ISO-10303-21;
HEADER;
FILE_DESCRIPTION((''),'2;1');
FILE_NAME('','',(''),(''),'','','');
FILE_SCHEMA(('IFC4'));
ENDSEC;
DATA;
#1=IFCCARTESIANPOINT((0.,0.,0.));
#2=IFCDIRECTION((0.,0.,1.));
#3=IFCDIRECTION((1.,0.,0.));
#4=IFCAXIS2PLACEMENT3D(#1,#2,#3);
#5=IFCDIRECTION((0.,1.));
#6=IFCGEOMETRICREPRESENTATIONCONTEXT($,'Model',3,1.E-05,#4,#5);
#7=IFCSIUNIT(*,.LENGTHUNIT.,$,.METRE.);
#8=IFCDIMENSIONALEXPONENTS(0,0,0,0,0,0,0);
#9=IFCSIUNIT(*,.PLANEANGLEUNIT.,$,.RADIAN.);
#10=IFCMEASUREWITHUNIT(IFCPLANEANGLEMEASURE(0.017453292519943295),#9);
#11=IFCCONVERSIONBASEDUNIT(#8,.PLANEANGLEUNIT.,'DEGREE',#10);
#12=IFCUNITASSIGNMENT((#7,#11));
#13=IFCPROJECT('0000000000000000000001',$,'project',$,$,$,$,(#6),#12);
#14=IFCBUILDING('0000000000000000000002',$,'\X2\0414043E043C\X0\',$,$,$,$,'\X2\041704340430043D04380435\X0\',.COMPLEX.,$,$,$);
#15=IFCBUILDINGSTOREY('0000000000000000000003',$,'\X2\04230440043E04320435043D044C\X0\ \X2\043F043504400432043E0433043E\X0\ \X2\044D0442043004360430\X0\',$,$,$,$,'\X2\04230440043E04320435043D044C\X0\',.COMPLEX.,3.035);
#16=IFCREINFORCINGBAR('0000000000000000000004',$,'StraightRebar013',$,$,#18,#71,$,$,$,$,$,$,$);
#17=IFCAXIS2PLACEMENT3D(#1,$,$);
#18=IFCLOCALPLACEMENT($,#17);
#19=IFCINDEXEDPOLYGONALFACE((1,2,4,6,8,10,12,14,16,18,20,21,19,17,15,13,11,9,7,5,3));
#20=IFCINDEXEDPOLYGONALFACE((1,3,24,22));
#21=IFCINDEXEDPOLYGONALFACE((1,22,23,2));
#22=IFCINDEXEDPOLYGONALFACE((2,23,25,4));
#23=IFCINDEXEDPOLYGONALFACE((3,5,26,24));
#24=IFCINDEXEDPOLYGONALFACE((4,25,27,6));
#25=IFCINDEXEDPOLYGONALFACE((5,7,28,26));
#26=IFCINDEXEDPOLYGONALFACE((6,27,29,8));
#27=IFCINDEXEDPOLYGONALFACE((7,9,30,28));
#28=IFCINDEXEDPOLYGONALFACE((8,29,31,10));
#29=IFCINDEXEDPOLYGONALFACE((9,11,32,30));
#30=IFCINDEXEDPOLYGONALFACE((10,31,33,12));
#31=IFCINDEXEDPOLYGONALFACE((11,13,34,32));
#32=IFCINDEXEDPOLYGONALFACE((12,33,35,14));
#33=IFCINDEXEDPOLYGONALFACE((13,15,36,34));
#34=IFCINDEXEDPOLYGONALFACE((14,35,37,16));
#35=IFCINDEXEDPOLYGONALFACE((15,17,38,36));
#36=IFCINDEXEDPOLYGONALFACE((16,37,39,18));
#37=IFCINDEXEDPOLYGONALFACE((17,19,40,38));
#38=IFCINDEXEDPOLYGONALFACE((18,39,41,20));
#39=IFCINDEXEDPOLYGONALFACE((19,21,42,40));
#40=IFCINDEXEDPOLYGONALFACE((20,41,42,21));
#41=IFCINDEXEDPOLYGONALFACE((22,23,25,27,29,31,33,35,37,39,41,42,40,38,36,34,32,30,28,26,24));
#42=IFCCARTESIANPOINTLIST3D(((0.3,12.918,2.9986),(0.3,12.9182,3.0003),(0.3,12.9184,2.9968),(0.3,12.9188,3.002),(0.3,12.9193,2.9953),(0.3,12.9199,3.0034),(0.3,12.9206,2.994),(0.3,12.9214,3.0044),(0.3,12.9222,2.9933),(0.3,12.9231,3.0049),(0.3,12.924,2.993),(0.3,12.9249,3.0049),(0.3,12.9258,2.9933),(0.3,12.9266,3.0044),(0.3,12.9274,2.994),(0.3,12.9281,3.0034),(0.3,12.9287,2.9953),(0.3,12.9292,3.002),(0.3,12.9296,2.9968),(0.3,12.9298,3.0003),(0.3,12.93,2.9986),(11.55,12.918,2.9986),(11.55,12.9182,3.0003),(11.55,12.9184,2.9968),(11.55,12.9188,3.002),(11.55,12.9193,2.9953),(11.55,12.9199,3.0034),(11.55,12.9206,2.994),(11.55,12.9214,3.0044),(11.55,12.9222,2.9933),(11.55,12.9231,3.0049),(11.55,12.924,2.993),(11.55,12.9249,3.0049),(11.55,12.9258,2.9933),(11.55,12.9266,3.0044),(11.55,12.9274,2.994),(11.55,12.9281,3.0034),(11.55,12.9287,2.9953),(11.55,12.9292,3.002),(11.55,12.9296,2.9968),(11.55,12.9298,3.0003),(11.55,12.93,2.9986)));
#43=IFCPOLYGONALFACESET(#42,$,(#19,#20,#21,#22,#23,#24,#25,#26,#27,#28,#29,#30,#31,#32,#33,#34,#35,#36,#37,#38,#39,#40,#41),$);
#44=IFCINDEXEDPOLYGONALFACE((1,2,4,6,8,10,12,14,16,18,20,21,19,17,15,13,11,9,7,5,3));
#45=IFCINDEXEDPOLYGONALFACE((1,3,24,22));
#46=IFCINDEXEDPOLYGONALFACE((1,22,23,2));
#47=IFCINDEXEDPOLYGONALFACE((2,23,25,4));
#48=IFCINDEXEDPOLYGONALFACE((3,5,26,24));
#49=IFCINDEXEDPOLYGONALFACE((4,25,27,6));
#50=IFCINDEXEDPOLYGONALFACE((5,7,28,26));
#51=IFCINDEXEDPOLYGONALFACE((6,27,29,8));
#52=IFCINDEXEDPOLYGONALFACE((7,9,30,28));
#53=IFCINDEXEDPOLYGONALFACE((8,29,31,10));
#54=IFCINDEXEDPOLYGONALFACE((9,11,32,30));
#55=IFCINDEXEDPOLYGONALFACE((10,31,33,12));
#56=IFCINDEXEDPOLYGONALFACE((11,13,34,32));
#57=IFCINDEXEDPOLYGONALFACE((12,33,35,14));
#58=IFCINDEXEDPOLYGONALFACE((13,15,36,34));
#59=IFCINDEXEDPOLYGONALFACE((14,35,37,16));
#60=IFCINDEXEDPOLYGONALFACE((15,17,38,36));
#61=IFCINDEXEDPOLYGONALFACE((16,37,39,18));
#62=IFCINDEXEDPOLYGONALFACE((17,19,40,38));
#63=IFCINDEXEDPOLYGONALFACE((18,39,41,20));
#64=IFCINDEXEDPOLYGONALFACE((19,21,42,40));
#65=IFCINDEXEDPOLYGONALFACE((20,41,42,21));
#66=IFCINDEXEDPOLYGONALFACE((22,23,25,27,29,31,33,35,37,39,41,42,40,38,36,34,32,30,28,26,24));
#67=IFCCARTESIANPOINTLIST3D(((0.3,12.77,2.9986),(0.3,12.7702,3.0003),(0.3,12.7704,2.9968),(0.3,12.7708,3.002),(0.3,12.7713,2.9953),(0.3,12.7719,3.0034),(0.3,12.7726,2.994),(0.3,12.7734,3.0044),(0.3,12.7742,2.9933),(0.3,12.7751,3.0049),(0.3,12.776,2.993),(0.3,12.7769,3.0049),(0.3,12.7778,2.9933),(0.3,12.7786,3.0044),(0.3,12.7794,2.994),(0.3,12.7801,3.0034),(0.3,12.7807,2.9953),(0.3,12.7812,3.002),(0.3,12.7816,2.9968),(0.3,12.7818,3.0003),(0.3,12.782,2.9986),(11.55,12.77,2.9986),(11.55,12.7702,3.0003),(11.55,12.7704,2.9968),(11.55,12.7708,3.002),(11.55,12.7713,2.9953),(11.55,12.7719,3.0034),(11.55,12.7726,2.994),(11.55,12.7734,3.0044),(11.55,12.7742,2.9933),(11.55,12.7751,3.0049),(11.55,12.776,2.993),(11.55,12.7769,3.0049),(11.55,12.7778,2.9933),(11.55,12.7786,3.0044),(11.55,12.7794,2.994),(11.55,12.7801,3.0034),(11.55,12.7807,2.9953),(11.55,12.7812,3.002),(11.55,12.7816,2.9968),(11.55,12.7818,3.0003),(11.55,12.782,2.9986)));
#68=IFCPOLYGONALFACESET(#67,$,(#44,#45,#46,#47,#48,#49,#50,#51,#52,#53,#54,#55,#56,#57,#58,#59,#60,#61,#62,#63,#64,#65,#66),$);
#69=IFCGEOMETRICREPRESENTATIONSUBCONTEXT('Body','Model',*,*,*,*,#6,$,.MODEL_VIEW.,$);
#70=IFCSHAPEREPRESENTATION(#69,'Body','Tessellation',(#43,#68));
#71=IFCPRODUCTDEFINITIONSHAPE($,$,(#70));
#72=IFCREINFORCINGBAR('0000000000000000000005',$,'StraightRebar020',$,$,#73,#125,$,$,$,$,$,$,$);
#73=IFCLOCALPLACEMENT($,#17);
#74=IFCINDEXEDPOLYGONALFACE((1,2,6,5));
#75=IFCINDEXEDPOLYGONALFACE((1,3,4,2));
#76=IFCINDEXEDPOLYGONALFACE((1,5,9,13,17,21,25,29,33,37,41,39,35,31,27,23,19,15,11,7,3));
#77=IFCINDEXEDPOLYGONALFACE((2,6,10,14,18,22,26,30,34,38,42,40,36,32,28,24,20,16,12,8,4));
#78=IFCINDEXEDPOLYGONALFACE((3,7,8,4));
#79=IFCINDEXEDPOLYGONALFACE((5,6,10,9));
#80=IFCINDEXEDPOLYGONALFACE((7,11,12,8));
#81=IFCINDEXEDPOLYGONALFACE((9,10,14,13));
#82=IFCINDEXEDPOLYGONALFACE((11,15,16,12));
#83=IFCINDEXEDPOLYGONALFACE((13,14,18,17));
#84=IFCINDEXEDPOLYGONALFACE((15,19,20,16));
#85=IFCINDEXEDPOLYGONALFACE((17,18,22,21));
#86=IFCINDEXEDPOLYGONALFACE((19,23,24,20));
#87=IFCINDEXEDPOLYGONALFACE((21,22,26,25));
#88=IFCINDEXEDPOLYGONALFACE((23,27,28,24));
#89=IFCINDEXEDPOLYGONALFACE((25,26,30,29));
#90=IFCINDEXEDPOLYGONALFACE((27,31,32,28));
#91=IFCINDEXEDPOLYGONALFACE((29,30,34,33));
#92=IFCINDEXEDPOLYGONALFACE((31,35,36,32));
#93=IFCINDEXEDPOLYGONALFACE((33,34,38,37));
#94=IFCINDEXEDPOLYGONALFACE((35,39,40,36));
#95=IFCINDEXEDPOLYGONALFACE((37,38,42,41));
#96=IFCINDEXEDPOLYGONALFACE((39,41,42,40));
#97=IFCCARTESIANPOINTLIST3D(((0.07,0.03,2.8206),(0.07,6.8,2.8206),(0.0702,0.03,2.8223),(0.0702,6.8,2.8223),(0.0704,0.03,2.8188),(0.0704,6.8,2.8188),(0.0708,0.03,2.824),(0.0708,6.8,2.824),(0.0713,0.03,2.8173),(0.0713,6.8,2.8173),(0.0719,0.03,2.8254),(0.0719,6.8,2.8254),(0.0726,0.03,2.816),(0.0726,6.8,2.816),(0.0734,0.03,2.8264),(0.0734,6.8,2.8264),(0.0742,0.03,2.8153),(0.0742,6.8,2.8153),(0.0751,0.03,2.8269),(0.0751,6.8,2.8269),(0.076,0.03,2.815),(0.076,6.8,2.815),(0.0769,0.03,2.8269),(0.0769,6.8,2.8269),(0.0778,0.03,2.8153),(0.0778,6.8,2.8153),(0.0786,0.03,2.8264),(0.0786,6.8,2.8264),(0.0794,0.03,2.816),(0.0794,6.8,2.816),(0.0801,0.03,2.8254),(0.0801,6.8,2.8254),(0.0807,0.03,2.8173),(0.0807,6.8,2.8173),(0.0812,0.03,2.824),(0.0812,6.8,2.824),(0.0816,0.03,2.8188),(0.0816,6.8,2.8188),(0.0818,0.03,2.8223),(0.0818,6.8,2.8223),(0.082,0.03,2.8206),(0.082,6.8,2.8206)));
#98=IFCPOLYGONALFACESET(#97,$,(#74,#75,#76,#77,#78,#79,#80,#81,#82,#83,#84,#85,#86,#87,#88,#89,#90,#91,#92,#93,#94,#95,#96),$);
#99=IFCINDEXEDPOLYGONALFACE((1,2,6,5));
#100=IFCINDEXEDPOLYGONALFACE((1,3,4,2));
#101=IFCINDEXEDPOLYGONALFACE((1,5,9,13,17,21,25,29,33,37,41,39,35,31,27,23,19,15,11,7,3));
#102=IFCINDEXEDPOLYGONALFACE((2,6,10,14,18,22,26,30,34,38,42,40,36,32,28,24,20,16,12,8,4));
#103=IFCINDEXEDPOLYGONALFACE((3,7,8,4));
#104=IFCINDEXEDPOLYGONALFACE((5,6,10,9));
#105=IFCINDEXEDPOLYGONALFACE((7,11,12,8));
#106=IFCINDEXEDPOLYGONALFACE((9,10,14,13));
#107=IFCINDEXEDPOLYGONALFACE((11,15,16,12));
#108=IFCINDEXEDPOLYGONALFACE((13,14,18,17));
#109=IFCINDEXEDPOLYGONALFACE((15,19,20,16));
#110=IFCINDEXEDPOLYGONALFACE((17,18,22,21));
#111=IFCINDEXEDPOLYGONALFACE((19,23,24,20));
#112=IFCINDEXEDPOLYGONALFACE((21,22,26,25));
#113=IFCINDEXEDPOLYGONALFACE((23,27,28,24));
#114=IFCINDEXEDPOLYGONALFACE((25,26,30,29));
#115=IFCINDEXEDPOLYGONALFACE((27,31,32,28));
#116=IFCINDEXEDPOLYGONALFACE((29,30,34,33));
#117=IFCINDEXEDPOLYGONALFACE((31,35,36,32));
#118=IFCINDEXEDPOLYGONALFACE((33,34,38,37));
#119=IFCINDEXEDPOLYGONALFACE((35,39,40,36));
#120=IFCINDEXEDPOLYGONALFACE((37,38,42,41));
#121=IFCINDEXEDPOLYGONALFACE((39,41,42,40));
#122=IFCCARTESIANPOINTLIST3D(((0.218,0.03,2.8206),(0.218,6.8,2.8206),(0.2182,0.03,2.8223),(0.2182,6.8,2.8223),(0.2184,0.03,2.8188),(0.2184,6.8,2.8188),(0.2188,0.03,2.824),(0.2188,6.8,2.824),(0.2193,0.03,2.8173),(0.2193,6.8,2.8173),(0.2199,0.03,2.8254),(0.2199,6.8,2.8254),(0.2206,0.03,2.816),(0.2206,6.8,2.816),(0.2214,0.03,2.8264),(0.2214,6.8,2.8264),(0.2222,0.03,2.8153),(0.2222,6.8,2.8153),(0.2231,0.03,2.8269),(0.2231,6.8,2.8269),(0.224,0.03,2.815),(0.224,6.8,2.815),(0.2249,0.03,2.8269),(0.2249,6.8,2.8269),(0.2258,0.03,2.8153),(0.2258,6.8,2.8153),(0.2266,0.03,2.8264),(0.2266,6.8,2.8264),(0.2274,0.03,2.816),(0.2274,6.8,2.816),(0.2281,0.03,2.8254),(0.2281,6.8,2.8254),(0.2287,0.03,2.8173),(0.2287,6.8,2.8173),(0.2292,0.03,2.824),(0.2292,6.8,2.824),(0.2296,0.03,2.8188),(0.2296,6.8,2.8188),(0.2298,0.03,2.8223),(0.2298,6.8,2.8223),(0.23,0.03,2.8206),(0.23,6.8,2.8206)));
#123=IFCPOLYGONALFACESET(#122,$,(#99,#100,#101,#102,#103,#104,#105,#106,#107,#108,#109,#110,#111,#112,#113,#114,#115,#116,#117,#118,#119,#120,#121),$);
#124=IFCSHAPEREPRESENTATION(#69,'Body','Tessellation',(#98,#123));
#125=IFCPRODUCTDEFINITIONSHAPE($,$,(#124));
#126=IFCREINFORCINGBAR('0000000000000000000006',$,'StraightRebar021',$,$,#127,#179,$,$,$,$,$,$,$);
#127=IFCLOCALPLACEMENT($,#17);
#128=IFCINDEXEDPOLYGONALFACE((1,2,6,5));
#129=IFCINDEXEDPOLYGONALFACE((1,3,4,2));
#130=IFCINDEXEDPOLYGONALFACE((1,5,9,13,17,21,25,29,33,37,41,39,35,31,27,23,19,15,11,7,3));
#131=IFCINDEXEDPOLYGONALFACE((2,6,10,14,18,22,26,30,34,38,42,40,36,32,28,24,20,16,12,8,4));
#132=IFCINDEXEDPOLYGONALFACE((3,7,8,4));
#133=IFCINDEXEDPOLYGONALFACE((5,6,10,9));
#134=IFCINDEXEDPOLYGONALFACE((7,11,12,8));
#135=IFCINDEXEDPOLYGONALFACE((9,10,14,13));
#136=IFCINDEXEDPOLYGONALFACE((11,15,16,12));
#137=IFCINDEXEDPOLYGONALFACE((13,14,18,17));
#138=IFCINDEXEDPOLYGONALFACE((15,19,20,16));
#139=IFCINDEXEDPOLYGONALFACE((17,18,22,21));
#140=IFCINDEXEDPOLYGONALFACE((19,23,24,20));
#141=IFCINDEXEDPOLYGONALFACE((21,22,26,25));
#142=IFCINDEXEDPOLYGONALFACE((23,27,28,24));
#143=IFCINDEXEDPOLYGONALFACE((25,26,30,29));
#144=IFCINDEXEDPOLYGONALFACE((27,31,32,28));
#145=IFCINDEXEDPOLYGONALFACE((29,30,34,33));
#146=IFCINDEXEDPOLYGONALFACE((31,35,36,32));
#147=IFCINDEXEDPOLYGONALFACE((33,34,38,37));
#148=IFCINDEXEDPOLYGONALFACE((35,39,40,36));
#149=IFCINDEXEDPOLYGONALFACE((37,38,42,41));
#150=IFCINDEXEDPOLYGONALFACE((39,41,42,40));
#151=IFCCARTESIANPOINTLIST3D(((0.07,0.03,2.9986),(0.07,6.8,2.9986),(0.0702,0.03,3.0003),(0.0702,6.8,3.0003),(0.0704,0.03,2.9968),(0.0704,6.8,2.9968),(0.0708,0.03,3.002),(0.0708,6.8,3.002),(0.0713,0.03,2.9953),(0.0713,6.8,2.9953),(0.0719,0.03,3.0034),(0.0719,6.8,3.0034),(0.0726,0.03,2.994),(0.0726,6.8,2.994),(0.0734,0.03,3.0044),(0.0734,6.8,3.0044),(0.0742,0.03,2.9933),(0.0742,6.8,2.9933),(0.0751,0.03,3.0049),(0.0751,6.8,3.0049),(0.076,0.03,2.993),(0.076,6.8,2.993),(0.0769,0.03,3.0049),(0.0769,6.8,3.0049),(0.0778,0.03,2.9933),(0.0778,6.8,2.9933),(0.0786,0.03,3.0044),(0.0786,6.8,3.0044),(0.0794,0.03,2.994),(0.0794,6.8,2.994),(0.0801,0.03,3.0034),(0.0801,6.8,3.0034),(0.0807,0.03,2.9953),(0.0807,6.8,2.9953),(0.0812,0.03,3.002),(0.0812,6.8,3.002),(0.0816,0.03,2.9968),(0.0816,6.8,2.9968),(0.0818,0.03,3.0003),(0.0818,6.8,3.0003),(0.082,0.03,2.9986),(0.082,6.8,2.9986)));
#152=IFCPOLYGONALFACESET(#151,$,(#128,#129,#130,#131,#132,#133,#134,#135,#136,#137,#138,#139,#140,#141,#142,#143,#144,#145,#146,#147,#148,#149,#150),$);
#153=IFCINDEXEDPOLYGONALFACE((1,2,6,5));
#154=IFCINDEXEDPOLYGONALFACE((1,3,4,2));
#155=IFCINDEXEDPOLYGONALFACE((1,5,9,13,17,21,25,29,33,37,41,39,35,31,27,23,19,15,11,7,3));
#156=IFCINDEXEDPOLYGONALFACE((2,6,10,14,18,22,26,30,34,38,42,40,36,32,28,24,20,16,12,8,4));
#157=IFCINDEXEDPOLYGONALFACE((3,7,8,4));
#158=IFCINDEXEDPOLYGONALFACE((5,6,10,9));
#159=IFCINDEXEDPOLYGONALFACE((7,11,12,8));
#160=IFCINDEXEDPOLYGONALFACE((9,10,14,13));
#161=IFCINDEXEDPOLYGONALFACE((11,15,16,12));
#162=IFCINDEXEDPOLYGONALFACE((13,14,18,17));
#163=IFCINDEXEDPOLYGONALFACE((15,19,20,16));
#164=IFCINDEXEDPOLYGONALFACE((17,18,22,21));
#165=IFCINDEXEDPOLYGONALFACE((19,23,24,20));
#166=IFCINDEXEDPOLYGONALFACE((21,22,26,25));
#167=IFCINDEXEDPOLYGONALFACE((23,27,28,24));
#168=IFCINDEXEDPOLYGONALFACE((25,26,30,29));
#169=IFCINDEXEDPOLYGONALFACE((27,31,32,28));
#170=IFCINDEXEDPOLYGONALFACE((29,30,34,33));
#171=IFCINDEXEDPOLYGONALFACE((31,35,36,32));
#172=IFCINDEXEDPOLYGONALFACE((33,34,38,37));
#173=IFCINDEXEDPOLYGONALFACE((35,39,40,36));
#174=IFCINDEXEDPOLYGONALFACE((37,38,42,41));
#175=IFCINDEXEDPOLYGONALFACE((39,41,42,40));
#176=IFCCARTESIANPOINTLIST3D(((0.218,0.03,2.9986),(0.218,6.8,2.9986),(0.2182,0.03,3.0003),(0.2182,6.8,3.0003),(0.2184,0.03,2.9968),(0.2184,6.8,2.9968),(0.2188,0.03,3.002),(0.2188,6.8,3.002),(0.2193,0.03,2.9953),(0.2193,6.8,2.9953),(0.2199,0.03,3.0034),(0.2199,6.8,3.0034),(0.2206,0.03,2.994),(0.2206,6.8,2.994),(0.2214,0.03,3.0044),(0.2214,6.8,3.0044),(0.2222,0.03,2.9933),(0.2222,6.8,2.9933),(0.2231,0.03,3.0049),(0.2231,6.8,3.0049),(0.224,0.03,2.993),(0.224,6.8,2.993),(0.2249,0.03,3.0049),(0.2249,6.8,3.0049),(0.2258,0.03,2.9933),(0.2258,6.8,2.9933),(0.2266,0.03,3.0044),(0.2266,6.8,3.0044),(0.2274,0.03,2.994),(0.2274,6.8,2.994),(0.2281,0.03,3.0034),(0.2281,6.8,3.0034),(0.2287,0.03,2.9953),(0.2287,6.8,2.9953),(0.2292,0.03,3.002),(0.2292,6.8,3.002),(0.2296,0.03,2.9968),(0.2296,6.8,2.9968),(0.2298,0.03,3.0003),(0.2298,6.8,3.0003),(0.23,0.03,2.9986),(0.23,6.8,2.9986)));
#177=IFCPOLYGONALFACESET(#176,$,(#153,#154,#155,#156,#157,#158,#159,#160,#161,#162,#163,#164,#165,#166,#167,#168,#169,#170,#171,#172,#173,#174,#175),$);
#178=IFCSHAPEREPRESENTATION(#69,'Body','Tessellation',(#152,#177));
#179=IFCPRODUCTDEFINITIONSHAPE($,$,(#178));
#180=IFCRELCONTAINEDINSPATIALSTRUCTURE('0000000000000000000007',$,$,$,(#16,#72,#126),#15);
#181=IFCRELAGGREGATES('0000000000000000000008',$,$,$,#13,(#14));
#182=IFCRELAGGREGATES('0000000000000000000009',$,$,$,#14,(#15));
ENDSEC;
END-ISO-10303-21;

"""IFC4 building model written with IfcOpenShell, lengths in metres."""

from ifc_helpers import new_model, entity, si_unit, converted_unit, direction, origin_with_axes, place, context, subcontext, project, spatial, element, save


model = new_model("IFC4")

# Units and contexts
model_context = context("Model", 3, precision=1e-05, world=origin_with_axes(), true_north=direction((0.0, 1.0)))
body_context = subcontext(model_context, "Body", "Model", "MODEL_VIEW")
ifc_project = project(units=[si_unit("LENGTHUNIT", "METRE"), converted_unit("PLANEANGLEUNIT", "DEGREE", entity("IfcPlaneAngleMeasure", 0.017453292519943295), si_unit("PLANEANGLEUNIT", "RADIAN"), dimensions=[0, 0, 0, 0, 0, 0, 0])], contexts=[model_context])

# Building, storey
building = spatial("IfcBuilding", under=ifc_project, Name="Дом", LongName="Здание", CompositionType="COMPLEX")
storey = spatial("IfcBuildingStorey", under=building, Name="Уровень первого этажа", LongName="Уровень", CompositionType="COMPLEX", Elevation=3.035)

# Shared definitions
placement = place(None, origin_with_axes())

# Reinforcing bars
element("IfcReinforcingBar", 1, at=placement, inside=storey, Name="StraightRebar013", context=body_context, shape_type="SweptSolid", body=[
    entity("IfcSweptDiskSolid", entity("IfcCompositeCurve", [entity("IfcCompositeCurveSegment", "CONTINUOUS", True, entity("IfcPolyline", [entity("IfcCartesianPoint", [11.55, 12.924, 2.999]), entity("IfcCartesianPoint", [0.3, 12.924, 2.999])]))], False), 0.006),
    entity("IfcSweptDiskSolid", entity("IfcCompositeCurve", [entity("IfcCompositeCurveSegment", "CONTINUOUS", True, entity("IfcPolyline", [entity("IfcCartesianPoint", [11.55, 12.776, 2.999]), entity("IfcCartesianPoint", [0.3, 12.776, 2.999])]))], False), 0.006),
])
element("IfcReinforcingBar", 2, at=placement, inside=storey, Name="StraightRebar020", context=body_context, shape_type="SweptSolid", body=[
    entity("IfcSweptDiskSolid", entity("IfcCompositeCurve", [entity("IfcCompositeCurveSegment", "CONTINUOUS", True, entity("IfcPolyline", [entity("IfcCartesianPoint", [0.076, 6.8, 2.821]), entity("IfcCartesianPoint", [0.076, 0.03, 2.821])]))], False), 0.006),
    entity("IfcSweptDiskSolid", entity("IfcCompositeCurve", [entity("IfcCompositeCurveSegment", "CONTINUOUS", True, entity("IfcPolyline", [entity("IfcCartesianPoint", [0.224, 6.8, 2.821]), entity("IfcCartesianPoint", [0.224, 0.03, 2.821])]))], False), 0.006),
])
element("IfcReinforcingBar", 3, at=placement, inside=storey, Name="StraightRebar021", context=body_context, shape_type="SweptSolid", body=[
    entity("IfcSweptDiskSolid", entity("IfcCompositeCurve", [entity("IfcCompositeCurveSegment", "CONTINUOUS", True, entity("IfcPolyline", [entity("IfcCartesianPoint", [0.076, 6.8, 2.999]), entity("IfcCartesianPoint", [0.076, 0.03, 2.999])]))], False), 0.006),
    entity("IfcSweptDiskSolid", entity("IfcCompositeCurve", [entity("IfcCompositeCurveSegment", "CONTINUOUS", True, entity("IfcPolyline", [entity("IfcCartesianPoint", [0.224, 6.8, 2.999]), entity("IfcCartesianPoint", [0.224, 0.03, 2.999])]))], False), 0.006),
])

save(model, "model.ifc")
